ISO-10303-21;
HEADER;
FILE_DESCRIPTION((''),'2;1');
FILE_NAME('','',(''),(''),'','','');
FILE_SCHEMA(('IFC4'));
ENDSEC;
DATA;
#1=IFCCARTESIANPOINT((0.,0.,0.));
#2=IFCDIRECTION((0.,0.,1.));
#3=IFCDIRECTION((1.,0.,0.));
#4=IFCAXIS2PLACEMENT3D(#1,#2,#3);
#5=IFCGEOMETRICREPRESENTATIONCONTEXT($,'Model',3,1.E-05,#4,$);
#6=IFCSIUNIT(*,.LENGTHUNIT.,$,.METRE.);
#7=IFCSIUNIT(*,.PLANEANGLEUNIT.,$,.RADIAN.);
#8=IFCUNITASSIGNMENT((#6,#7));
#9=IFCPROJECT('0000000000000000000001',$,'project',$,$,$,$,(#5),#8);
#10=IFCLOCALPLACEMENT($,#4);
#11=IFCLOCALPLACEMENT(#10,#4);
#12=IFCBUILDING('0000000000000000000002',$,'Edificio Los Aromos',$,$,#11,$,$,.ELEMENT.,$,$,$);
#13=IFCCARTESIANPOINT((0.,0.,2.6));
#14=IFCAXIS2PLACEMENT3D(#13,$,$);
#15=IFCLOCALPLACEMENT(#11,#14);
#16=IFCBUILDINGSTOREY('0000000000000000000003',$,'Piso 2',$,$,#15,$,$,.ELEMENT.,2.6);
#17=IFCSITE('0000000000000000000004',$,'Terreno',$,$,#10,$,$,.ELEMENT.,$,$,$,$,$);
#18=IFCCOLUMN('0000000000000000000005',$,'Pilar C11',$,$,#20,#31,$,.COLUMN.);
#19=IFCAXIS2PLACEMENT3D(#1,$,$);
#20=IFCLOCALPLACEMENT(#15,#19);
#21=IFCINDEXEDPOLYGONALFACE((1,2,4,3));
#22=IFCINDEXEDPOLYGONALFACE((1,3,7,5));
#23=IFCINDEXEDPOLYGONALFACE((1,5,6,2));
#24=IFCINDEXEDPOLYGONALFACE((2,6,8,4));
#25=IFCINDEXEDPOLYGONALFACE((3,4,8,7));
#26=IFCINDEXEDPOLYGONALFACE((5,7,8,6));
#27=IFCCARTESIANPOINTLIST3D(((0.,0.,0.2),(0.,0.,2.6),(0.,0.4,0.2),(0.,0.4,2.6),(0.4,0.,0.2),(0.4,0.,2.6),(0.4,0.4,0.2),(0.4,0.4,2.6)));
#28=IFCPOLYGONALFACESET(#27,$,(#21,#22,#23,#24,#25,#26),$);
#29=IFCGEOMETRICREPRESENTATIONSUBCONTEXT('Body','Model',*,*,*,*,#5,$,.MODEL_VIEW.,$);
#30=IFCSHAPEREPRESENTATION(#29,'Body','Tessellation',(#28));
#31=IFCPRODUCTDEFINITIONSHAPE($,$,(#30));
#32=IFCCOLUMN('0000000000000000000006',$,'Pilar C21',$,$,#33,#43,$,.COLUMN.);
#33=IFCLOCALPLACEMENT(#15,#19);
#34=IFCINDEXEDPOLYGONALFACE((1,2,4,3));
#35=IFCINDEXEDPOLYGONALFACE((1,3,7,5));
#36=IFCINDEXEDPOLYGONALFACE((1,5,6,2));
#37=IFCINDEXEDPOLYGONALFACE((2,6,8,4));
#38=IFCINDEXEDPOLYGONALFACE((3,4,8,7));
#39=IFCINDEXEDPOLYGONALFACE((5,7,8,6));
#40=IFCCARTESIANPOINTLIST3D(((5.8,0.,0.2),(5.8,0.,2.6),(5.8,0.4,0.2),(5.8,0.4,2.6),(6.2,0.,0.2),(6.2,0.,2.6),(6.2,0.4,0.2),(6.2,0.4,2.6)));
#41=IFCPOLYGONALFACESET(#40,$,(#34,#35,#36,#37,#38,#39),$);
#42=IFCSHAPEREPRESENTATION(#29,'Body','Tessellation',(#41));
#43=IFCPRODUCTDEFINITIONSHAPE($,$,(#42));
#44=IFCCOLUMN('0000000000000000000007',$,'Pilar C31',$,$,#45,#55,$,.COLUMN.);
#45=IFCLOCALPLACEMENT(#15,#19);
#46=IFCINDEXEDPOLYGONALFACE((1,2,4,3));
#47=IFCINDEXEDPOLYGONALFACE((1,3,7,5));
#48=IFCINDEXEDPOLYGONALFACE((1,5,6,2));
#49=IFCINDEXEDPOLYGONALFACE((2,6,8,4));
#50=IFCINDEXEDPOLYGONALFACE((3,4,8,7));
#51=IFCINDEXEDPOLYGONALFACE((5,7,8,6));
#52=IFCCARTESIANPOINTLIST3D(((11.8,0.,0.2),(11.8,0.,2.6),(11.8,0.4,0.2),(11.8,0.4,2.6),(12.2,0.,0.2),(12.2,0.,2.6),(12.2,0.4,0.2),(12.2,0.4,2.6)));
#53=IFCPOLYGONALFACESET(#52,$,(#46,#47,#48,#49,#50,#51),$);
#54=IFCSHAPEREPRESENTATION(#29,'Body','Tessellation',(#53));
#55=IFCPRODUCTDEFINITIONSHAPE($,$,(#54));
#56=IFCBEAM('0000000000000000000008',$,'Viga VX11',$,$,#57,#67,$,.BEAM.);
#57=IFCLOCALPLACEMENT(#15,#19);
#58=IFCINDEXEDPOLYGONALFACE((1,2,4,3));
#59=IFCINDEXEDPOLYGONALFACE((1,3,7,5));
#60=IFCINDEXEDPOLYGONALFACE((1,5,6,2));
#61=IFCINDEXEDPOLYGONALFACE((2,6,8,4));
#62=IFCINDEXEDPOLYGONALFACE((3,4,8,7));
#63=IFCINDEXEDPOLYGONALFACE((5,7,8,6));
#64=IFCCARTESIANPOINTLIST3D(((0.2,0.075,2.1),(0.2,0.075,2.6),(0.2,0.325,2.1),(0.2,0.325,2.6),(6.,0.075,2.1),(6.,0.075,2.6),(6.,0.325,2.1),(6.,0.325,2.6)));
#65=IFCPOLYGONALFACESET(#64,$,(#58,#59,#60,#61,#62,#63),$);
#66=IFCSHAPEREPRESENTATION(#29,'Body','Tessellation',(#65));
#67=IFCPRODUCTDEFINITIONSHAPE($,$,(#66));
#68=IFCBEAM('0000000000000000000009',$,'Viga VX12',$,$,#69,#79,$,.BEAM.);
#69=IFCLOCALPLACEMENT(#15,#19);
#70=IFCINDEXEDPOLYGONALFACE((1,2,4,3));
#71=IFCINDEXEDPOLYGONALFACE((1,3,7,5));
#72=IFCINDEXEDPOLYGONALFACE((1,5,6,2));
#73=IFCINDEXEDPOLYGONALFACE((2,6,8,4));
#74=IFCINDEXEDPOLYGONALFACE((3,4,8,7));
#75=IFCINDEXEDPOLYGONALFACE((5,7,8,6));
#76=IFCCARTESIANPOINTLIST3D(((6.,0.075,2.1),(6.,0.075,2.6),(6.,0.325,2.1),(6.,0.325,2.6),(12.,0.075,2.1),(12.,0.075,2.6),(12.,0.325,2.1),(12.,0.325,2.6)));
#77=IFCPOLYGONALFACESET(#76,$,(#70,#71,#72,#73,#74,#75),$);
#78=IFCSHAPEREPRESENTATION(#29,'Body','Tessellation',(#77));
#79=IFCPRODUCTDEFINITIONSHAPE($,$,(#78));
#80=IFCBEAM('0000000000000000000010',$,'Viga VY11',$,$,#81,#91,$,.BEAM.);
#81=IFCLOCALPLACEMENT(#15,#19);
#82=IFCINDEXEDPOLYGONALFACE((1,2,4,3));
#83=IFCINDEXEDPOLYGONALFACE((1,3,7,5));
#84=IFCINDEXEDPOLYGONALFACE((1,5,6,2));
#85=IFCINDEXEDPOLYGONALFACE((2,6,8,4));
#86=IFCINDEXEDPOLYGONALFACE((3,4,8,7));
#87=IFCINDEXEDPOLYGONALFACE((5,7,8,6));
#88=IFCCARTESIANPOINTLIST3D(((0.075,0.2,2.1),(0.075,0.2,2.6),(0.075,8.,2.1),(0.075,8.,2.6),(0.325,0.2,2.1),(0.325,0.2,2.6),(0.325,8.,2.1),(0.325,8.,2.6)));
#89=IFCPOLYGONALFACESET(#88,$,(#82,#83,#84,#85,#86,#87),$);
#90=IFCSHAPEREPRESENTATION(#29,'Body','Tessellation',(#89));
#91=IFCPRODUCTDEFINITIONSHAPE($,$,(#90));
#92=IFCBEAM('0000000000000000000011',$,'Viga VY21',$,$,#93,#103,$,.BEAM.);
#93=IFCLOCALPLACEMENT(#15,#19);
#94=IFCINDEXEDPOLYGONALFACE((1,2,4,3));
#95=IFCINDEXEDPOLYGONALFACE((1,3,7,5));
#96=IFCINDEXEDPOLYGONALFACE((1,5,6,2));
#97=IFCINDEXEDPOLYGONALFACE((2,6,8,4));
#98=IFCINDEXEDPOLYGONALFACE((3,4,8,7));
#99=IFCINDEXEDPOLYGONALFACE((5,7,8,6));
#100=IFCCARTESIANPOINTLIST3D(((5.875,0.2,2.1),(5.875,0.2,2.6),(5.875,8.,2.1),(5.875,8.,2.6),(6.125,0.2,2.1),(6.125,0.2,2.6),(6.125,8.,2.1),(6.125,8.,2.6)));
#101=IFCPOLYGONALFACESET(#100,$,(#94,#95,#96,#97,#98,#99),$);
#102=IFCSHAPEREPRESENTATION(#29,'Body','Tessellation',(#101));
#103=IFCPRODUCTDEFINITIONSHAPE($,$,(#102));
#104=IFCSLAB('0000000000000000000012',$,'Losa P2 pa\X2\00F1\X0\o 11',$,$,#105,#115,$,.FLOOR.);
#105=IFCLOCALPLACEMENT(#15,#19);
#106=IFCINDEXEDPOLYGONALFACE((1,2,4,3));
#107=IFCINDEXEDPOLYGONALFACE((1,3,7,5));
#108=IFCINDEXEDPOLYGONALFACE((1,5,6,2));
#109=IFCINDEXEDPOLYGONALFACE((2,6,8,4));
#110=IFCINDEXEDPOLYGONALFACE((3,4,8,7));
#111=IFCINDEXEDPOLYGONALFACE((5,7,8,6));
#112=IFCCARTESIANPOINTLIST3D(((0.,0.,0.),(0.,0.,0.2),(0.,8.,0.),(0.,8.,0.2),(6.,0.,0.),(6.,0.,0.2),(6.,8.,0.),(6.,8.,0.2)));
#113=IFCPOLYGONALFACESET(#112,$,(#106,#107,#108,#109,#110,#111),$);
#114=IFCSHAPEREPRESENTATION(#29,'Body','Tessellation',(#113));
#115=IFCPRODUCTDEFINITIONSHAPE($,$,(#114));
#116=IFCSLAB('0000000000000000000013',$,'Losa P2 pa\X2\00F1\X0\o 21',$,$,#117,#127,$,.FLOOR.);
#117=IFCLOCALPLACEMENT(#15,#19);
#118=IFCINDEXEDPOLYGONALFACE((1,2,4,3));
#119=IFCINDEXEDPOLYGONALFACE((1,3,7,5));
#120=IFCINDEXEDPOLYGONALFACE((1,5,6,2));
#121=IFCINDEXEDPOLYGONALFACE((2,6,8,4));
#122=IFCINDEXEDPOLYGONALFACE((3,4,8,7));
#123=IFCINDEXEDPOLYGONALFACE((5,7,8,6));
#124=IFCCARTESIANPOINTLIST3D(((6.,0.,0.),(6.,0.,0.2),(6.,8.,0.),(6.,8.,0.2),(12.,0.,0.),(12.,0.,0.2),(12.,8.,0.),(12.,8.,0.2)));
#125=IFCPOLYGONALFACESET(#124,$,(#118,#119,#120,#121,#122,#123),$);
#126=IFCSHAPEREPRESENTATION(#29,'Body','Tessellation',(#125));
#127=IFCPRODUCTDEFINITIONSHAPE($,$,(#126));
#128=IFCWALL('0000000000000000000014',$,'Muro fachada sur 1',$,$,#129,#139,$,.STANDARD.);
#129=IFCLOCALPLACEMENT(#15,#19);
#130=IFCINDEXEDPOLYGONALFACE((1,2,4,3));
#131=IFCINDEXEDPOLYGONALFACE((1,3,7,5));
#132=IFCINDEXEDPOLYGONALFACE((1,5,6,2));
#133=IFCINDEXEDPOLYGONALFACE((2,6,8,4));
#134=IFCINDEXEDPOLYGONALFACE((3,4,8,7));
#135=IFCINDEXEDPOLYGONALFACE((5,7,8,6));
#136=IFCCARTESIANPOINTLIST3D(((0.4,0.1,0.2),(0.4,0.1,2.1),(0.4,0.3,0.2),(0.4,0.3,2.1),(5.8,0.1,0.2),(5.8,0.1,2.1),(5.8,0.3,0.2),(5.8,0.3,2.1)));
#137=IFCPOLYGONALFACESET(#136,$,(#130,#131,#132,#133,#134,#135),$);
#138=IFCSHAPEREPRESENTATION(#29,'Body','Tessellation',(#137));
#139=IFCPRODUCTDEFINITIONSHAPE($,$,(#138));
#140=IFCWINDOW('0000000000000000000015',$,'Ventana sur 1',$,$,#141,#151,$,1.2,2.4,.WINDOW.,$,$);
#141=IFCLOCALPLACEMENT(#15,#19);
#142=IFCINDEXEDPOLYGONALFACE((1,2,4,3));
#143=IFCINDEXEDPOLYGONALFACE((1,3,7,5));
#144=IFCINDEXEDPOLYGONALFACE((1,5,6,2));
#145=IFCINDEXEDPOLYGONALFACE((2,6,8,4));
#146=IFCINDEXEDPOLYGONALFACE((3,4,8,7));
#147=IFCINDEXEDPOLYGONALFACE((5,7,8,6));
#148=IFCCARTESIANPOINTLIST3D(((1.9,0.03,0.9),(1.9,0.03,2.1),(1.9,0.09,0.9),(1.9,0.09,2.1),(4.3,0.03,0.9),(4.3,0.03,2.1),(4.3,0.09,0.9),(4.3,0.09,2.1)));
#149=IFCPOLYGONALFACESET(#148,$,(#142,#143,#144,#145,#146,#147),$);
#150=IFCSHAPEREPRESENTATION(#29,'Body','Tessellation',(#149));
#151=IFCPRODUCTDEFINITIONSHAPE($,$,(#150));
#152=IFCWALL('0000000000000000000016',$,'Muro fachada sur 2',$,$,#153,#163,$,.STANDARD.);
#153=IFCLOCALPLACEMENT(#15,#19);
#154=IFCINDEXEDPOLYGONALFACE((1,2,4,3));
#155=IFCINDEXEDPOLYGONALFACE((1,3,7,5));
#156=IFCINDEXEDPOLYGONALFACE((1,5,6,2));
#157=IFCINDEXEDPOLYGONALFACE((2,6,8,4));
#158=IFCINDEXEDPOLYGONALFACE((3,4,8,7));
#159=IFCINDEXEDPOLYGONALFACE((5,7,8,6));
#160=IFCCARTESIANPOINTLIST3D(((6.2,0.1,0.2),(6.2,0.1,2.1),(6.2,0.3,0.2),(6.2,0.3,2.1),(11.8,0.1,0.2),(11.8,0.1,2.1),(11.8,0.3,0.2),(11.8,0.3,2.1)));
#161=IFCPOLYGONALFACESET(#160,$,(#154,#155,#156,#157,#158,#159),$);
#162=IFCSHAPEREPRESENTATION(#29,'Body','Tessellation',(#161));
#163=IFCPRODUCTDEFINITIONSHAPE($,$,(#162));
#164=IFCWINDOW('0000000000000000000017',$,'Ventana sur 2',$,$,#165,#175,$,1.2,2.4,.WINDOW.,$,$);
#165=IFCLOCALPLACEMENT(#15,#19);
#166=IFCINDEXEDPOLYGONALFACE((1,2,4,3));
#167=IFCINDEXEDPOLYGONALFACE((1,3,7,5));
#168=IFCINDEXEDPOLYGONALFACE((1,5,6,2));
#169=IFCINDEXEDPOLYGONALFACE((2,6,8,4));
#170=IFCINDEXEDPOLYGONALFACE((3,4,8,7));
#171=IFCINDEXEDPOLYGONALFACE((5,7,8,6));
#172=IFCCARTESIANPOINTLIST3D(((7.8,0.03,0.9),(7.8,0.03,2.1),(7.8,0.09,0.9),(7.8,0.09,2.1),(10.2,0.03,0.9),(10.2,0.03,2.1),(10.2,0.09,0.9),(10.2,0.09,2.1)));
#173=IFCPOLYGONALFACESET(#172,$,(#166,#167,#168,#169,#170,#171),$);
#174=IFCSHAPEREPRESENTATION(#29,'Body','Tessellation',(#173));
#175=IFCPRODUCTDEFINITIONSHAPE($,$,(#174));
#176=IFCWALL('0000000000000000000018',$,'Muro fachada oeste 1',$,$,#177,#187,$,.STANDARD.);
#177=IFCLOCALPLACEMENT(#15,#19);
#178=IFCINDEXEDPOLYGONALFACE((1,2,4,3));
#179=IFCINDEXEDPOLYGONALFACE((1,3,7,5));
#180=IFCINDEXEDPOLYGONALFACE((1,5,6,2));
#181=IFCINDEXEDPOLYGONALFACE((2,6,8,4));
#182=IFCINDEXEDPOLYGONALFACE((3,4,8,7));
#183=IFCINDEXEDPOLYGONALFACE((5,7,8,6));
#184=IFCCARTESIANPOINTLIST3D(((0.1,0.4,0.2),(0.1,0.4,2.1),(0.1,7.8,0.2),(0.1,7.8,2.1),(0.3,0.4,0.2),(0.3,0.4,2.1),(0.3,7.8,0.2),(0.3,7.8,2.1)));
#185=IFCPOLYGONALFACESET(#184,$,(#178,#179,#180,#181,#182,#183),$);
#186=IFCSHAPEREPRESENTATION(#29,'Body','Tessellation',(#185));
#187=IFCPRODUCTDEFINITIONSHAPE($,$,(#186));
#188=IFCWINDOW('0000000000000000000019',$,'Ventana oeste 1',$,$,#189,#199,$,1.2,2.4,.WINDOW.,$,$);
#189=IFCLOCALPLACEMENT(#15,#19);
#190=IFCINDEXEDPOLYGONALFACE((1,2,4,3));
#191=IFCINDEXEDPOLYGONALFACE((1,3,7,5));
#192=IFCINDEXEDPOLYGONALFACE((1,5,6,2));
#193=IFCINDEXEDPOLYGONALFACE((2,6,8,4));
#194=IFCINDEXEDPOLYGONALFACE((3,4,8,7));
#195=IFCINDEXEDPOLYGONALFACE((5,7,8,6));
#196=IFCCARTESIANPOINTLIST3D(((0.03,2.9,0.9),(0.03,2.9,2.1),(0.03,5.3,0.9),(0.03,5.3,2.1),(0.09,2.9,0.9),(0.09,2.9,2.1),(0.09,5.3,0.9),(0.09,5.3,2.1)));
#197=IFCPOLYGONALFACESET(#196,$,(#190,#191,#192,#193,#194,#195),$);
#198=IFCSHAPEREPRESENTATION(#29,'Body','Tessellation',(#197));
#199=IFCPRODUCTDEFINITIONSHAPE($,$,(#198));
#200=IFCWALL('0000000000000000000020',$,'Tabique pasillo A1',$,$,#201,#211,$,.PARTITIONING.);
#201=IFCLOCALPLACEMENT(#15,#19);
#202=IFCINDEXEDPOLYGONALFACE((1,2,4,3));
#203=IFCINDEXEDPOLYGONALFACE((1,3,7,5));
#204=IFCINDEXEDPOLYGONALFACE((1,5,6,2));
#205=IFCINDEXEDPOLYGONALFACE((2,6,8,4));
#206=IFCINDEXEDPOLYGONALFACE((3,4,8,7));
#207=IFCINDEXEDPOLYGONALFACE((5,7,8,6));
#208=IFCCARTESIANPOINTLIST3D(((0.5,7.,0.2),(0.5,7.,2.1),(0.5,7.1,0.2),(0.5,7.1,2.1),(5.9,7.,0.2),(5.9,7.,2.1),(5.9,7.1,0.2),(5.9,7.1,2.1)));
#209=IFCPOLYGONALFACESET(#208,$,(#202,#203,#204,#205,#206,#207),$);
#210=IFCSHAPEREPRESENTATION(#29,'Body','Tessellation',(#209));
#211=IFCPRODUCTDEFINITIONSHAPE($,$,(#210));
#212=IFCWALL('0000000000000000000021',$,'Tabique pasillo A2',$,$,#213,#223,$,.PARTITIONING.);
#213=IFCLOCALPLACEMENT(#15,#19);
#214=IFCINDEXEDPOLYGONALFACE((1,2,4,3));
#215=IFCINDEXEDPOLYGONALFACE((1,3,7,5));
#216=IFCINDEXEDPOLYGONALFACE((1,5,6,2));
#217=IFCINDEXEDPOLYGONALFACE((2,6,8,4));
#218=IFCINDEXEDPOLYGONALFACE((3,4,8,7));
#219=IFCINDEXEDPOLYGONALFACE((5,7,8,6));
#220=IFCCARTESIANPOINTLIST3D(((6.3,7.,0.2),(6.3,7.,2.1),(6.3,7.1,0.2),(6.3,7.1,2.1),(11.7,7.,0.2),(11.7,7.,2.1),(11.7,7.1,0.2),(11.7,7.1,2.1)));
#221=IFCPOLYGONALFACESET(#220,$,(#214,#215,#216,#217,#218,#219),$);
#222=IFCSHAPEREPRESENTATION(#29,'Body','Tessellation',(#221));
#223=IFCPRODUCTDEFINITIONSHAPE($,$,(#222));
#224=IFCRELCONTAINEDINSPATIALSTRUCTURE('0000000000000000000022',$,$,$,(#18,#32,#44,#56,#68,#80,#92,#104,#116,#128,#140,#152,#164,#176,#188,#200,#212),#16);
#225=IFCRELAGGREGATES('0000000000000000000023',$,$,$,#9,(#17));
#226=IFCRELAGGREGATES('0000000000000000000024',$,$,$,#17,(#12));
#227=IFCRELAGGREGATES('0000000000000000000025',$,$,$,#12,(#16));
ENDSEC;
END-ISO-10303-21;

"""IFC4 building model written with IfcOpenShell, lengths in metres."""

from ifc_helpers import new_model, si_unit, frame, frame_2d, origin_with_axes, place, context, subcontext, project, spatial, rectangle, extrude, element, save


model = new_model("IFC4")

# Units and contexts
model_context = context("Model", 3, precision=1e-05, world=origin_with_axes())
body_context = subcontext(model_context, "Body", "Model", "MODEL_VIEW")
ifc_project = project(units=[si_unit("LENGTHUNIT", "METRE"), si_unit("PLANEANGLEUNIT", "RADIAN")], contexts=[model_context])

# Site, building, storey
site_placement = place(None, origin_with_axes())
site = spatial("IfcSite", under=ifc_project, at=site_placement, Name="Terreno", CompositionType="ELEMENT")
building_placement = place(site_placement, origin_with_axes())
building = spatial("IfcBuilding", under=site, at=building_placement, Name="Edificio Los Aromos", CompositionType="ELEMENT")
storey_placement = place(building_placement, frame((0.0, 0.0, 2.6)))
storey = spatial("IfcBuildingStorey", under=building, at=storey_placement, Name="Piso 2", CompositionType="ELEMENT", Elevation=2.6)

# Columns
for number, where, name in (
    (1, (0.0, 0.0, 0.2), "Pilar C11"),
    (2, (5.8, 0.0, 0.2), "Pilar C21"),
    (3, (11.8, 0.0, 0.2), "Pilar C31"),
):
    element("IfcColumn", number, at=place(storey_placement, frame(where)), inside=storey, Name=name, PredefinedType="COLUMN", context=body_context, shape_type="SweptSolid", body=[
        extrude(rectangle(XDim=0.4, YDim=0.4, at=frame_2d((0.2, 0.2))), origin_with_axes(), (0.0, 0.0, 1.0), 2.4),
    ])

# Beams
beam_1_placement = place(storey_placement, frame((0.2, 0.075, 2.1)))
element("IfcBeam", 4, at=beam_1_placement, inside=storey, Name="Viga VX11", PredefinedType="BEAM", context=body_context, shape_type="SweptSolid", body=[
    extrude(rectangle(XDim=5.8, YDim=0.25, at=frame_2d((2.9, 0.125))), origin_with_axes(), (0.0, 0.0, 1.0), 0.5),
])
beam_2_placement = place(storey_placement, frame((6.0, 0.075, 2.1)))
element("IfcBeam", 5, at=beam_2_placement, inside=storey, Name="Viga VX12", PredefinedType="BEAM", context=body_context, shape_type="SweptSolid", body=[
    extrude(rectangle(XDim=6.0, YDim=0.25, at=frame_2d((3.0, 0.125))), origin_with_axes(), (0.0, 0.0, 1.0), 0.5),
])
for number, where, name in (
    (6, (0.075, 0.2, 2.1), "Viga VY11"),
    (7, (5.875, 0.2, 2.1), "Viga VY21"),
):
    element("IfcBeam", number, at=place(storey_placement, frame(where)), inside=storey, Name=name, PredefinedType="BEAM", context=body_context, shape_type="SweptSolid", body=[
        extrude(rectangle(XDim=0.25, YDim=7.8, at=frame_2d((0.125, 3.9))), origin_with_axes(), (0.0, 0.0, 1.0), 0.5),
    ])

# Slabs
for number, where, name in (
    (8, (0.0, 0.0, 0.0), "Losa P2 paño 11"),
    (9, (6.0, 0.0, 0.0), "Losa P2 paño 21"),
):
    element("IfcSlab", number, at=place(storey_placement, frame(where)), inside=storey, Name=name, PredefinedType="FLOOR", context=body_context, shape_type="SweptSolid", body=[
        extrude(rectangle(XDim=6.0, YDim=8.0, at=frame_2d((3.0, 4.0))), origin_with_axes(), (0.0, 0.0, 1.0), 0.2),
    ])

# Wall
wall_1_placement = place(storey_placement, frame((0.4, 0.1, 0.2)))
element("IfcWall", 10, at=wall_1_placement, inside=storey, Name="Muro fachada sur 1", PredefinedType="STANDARD", context=body_context, shape_type="SweptSolid", body=[
    extrude(rectangle(XDim=5.4, YDim=0.2, at=frame_2d((2.7, 0.1))), origin_with_axes(), (0.0, 0.0, 1.0), 1.9),
])

# Window
window_1_placement = place(storey_placement, frame((1.9, 0.03, 0.9)))
element("IfcWindow", 11, at=window_1_placement, inside=storey, Name="Ventana sur 1", OverallHeight=1.2, OverallWidth=2.4, PredefinedType="WINDOW", context=body_context, shape_type="SweptSolid", body=[
    extrude(rectangle(XDim=2.4, YDim=0.06, at=frame_2d((1.2, 0.03))), origin_with_axes(), (0.0, 0.0, 1.0), 1.2),
])

# Wall
wall_2_placement = place(storey_placement, frame((6.2, 0.1, 0.2)))
element("IfcWall", 12, at=wall_2_placement, inside=storey, Name="Muro fachada sur 2", PredefinedType="STANDARD", context=body_context, shape_type="SweptSolid", body=[
    extrude(rectangle(XDim=5.6, YDim=0.2, at=frame_2d((2.8, 0.1))), origin_with_axes(), (0.0, 0.0, 1.0), 1.9),
])

# Window
window_2_placement = place(storey_placement, frame((7.8, 0.03, 0.9)))
element("IfcWindow", 13, at=window_2_placement, inside=storey, Name="Ventana sur 2", OverallHeight=1.2, OverallWidth=2.4, PredefinedType="WINDOW", context=body_context, shape_type="SweptSolid", body=[
    extrude(rectangle(XDim=2.4, YDim=0.06, at=frame_2d((1.2, 0.03))), origin_with_axes(), (0.0, 0.0, 1.0), 1.2),
])

# Wall
wall_3_placement = place(storey_placement, frame((0.1, 0.4, 0.2)))
element("IfcWall", 14, at=wall_3_placement, inside=storey, Name="Muro fachada oeste 1", PredefinedType="STANDARD", context=body_context, shape_type="SweptSolid", body=[
    extrude(rectangle(XDim=0.2, YDim=7.4, at=frame_2d((0.1, 3.7))), origin_with_axes(), (0.0, 0.0, 1.0), 1.9),
])

# Window
window_3_placement = place(storey_placement, frame((0.03, 2.9, 0.9)))
element("IfcWindow", 15, at=window_3_placement, inside=storey, Name="Ventana oeste 1", OverallHeight=1.2, OverallWidth=2.4, PredefinedType="WINDOW", context=body_context, shape_type="SweptSolid", body=[
    extrude(rectangle(XDim=0.06, YDim=2.4, at=frame_2d((0.03, 1.2))), origin_with_axes(), (0.0, 0.0, 1.0), 1.2),
])

# Walls
for number, where, name in (
    (16, (0.5, 7.0, 0.2), "Tabique pasillo A1"),
    (17, (6.3, 7.0, 0.2), "Tabique pasillo A2"),
):
    element("IfcWall", number, at=place(storey_placement, frame(where)), inside=storey, Name=name, PredefinedType="PARTITIONING", context=body_context, shape_type="SweptSolid", body=[
        extrude(rectangle(XDim=5.4, YDim=0.1, at=frame_2d((2.7, 0.05))), origin_with_axes(), (0.0, 0.0, 1.0), 1.9),
    ])

save(model, "model.ifc")
